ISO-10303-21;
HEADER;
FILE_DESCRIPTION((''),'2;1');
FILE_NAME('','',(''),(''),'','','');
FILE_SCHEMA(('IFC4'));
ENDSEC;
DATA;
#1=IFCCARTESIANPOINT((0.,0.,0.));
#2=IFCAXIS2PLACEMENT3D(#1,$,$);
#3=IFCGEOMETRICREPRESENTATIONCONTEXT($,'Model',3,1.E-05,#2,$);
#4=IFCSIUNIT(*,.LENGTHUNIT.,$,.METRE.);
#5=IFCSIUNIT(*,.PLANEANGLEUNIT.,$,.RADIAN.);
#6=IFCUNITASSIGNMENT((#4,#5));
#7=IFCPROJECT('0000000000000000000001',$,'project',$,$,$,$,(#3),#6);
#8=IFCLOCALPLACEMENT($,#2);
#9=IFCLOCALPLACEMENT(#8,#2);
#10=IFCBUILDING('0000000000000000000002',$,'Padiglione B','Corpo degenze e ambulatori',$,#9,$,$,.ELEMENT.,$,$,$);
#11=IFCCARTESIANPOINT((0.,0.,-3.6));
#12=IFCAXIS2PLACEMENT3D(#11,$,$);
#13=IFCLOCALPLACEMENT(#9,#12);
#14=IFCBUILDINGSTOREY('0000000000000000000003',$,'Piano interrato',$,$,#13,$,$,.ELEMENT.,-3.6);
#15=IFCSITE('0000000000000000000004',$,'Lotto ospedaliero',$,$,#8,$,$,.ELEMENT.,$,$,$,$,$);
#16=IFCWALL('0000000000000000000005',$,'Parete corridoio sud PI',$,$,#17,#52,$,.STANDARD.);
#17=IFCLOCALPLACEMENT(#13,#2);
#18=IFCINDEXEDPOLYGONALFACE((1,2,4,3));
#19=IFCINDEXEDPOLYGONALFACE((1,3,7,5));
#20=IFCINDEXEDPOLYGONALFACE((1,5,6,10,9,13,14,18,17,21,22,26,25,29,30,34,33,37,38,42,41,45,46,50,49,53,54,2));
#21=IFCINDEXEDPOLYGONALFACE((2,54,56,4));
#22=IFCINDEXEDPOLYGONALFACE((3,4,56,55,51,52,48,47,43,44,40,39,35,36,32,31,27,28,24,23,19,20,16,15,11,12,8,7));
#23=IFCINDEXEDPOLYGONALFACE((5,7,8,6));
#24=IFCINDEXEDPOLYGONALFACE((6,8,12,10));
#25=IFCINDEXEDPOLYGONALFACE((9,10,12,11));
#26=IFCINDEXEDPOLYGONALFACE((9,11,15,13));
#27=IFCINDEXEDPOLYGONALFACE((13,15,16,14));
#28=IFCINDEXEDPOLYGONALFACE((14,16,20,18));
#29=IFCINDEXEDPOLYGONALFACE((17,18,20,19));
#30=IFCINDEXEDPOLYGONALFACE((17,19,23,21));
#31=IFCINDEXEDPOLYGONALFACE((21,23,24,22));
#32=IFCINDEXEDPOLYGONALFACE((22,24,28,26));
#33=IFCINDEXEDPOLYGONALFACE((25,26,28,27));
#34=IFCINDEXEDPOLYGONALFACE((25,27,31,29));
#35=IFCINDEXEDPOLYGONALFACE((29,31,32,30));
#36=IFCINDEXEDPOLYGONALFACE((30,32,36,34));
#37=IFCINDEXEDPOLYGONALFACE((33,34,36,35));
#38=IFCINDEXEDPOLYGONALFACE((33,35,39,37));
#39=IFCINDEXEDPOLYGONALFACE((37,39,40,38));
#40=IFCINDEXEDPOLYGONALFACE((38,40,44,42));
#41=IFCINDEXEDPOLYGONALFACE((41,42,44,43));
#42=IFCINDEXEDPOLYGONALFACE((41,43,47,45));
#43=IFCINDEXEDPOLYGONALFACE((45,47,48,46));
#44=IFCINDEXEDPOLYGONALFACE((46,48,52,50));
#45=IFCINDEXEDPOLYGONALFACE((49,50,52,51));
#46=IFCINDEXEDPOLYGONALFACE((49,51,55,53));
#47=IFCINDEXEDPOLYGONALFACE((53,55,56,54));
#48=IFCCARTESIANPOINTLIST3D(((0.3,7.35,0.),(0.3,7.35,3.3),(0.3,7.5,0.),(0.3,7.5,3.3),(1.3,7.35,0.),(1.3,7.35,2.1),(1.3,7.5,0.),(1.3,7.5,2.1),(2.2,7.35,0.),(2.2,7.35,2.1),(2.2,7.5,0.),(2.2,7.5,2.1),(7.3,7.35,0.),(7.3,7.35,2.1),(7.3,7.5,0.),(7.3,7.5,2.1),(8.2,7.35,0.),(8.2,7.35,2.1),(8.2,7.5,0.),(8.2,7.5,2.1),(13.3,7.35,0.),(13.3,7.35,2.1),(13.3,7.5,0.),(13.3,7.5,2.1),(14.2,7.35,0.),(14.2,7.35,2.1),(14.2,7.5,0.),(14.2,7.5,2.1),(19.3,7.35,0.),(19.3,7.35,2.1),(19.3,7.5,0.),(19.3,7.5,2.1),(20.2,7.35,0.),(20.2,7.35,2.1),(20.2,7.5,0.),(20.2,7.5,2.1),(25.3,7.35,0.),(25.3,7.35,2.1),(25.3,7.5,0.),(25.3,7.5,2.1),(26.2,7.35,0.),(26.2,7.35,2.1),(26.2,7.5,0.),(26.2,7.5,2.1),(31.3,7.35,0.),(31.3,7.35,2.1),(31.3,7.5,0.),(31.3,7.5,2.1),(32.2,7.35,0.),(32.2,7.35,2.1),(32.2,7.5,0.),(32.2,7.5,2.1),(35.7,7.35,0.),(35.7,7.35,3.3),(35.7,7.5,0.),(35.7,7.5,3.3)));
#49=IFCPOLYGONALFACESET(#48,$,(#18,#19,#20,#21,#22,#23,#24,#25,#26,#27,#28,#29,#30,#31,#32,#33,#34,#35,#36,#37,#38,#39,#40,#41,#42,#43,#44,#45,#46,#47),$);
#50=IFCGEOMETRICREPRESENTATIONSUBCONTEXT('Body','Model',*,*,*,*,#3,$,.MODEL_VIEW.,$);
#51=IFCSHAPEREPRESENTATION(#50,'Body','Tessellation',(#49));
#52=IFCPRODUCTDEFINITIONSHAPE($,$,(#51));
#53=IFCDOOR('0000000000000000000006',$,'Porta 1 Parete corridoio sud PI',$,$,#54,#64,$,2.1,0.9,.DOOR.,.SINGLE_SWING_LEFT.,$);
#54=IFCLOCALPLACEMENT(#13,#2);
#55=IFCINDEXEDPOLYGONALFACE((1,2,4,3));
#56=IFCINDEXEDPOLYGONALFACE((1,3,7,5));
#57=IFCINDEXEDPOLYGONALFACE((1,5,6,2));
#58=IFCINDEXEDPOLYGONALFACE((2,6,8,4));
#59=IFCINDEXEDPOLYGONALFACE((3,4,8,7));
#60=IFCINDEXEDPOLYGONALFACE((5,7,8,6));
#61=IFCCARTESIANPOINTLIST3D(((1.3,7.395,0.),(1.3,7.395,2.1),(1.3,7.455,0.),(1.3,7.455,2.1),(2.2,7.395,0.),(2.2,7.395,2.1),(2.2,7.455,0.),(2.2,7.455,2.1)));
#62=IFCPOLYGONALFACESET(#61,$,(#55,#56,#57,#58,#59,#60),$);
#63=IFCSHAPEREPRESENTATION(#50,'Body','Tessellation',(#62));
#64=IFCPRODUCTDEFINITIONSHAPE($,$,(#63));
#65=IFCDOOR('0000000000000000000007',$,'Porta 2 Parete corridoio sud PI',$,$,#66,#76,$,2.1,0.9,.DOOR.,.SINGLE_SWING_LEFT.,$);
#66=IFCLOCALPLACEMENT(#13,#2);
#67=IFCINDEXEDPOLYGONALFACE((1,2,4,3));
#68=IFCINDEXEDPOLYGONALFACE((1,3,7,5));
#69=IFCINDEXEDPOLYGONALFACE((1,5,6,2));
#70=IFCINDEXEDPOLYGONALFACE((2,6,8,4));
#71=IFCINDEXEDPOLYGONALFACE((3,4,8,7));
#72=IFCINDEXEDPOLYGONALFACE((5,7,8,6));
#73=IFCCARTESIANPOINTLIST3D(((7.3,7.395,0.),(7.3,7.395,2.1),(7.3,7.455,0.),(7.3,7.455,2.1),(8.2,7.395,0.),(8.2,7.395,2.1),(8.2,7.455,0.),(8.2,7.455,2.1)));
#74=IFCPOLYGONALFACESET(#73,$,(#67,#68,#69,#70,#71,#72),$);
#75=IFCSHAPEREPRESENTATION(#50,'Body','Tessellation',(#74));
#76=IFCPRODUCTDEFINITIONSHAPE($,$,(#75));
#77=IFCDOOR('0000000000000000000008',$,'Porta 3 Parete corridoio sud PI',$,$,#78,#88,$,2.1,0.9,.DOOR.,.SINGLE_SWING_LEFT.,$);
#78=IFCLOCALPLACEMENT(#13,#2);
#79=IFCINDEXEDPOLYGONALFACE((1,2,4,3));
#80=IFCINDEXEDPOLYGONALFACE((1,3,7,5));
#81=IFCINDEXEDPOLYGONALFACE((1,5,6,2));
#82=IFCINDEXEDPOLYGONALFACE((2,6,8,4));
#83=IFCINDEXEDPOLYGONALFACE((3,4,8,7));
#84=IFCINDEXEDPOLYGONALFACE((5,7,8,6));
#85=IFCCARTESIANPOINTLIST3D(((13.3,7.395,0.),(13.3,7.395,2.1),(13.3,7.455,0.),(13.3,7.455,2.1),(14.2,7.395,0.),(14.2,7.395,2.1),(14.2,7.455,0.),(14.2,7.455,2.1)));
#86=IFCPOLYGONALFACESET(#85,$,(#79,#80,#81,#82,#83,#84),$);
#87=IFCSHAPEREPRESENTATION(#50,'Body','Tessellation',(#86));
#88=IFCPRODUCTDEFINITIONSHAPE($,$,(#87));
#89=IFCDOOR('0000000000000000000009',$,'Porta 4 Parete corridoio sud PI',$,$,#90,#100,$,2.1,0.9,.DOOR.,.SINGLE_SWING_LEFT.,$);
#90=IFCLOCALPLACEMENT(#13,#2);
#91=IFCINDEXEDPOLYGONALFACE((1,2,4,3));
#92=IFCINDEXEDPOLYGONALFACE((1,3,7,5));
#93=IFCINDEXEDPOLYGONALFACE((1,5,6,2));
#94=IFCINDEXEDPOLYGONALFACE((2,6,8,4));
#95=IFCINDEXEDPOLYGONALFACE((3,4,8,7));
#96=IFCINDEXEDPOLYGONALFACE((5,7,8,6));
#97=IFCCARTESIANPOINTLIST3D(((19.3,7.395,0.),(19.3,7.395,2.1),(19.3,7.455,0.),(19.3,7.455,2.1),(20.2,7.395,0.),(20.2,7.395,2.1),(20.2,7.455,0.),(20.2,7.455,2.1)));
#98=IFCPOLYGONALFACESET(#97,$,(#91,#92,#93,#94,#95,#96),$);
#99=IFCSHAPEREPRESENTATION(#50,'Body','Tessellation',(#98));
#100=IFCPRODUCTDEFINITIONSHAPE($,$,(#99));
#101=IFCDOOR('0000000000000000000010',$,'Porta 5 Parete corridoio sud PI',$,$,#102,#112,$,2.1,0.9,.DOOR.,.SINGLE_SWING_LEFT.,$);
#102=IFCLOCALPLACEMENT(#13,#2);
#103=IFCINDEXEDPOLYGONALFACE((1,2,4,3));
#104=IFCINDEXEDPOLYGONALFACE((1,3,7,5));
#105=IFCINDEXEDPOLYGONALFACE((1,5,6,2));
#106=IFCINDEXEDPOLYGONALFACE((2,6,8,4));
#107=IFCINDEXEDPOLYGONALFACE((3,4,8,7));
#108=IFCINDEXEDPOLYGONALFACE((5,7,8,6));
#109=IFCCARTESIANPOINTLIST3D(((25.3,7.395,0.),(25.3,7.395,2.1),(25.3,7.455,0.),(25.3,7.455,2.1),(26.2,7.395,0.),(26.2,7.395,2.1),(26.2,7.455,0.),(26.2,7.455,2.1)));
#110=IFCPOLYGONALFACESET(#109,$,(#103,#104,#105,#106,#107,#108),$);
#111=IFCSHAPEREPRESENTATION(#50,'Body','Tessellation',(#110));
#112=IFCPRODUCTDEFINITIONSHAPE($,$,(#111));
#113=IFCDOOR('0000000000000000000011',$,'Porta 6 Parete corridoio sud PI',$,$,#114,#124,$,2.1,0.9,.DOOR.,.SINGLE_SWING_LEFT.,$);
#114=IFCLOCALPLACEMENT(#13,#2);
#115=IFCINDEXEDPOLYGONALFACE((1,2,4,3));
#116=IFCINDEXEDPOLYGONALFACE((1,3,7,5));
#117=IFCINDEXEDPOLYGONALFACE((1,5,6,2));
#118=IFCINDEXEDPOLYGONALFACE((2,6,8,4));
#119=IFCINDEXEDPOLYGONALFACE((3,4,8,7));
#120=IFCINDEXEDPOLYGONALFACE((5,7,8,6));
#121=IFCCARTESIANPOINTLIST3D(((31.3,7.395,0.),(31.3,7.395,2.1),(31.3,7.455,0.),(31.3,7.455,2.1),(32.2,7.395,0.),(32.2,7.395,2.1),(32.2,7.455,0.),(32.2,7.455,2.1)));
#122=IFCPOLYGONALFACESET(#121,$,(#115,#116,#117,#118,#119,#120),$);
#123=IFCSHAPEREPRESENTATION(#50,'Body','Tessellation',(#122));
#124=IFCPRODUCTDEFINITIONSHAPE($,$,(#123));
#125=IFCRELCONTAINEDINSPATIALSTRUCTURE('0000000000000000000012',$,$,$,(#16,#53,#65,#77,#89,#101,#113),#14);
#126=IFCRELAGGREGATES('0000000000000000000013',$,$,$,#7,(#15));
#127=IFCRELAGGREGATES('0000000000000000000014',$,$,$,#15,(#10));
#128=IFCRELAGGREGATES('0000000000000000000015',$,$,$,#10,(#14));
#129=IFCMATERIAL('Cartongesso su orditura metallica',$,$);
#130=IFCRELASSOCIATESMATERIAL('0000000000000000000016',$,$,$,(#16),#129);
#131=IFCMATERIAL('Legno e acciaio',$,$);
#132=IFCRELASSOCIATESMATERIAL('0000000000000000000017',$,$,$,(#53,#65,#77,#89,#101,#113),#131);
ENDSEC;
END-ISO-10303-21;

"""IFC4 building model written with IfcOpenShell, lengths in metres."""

from ifc_helpers import new_model, si_unit, frame, frame_2d, origin, place, context, subcontext, project, spatial, rectangle, extrude, material, element, fill, save


model = new_model("IFC4")

# Units and contexts
model_context = context("Model", 3, precision=1e-05, world=origin())
body_context = subcontext(model_context, "Body", "Model", "MODEL_VIEW")
ifc_project = project(units=[si_unit("LENGTHUNIT", "METRE"), si_unit("PLANEANGLEUNIT", "RADIAN")], contexts=[model_context])

# Site, building, storey
site_placement = place(None, origin())
site = spatial("IfcSite", under=ifc_project, at=site_placement, Name="Lotto ospedaliero", CompositionType="ELEMENT")
building_placement = place(site_placement, origin())
building = spatial("IfcBuilding", under=site, at=building_placement, Name="Padiglione B", Description="Corpo degenze e ambulatori", CompositionType="ELEMENT")
storey_placement = place(building_placement, frame((0.0, 0.0, -3.6)))
storey = spatial("IfcBuildingStorey", under=building, at=storey_placement, Name="Piano interrato", CompositionType="ELEMENT", Elevation=-3.6)

# Wall, openings, doors
ifc_material_1 = material(Name="Cartongesso su orditura metallica")
wall_1_placement = place(storey_placement, frame((0.3, 7.35, 0.0)))
wall_1 = element("IfcWall", 1, at=wall_1_placement, inside=storey, material=ifc_material_1, Name="Parete corridoio sud PI", PredefinedType="STANDARD", context=body_context, shape_type="SweptSolid", body=[
    extrude(rectangle(XDim=35.4, YDim=0.15, at=frame_2d((17.7, 0.075))), origin(), (0.0, 0.0, 1.0), 3.3),
])
opening_1_placement = place(wall_1_placement, frame((1.0, -0.1, 0.0)))
opening_1 = element("IfcOpeningElement", 2, at=opening_1_placement, cuts=wall_1, PredefinedType="OPENING", context=body_context, shape_type="SweptSolid", body=[
    extrude(rectangle(XDim=0.9, YDim=0.35, at=frame_2d((0.45, 0.175))), origin(), (0.0, 0.0, 1.0), 2.1),
])
opening_2_placement = place(wall_1_placement, frame((7.0, -0.1, 0.0)))
opening_2 = element("IfcOpeningElement", 3, at=opening_2_placement, cuts=wall_1, PredefinedType="OPENING", context=body_context, shape_type="SweptSolid", body=[
    extrude(rectangle(XDim=0.9, YDim=0.35, at=frame_2d((0.45, 0.175))), origin(), (0.0, 0.0, 1.0), 2.1),
])
opening_3_placement = place(wall_1_placement, frame((13.0, -0.1, 0.0)))
opening_3 = element("IfcOpeningElement", 4, at=opening_3_placement, cuts=wall_1, PredefinedType="OPENING", context=body_context, shape_type="SweptSolid", body=[
    extrude(rectangle(XDim=0.9, YDim=0.35, at=frame_2d((0.45, 0.175))), origin(), (0.0, 0.0, 1.0), 2.1),
])
opening_4_placement = place(wall_1_placement, frame((19.0, -0.1, 0.0)))
opening_4 = element("IfcOpeningElement", 5, at=opening_4_placement, cuts=wall_1, PredefinedType="OPENING", context=body_context, shape_type="SweptSolid", body=[
    extrude(rectangle(XDim=0.9, YDim=0.35, at=frame_2d((0.45, 0.175))), origin(), (0.0, 0.0, 1.0), 2.1),
])
opening_5_placement = place(wall_1_placement, frame((25.0, -0.1, 0.0)))
opening_5 = element("IfcOpeningElement", 6, at=opening_5_placement, cuts=wall_1, PredefinedType="OPENING", context=body_context, shape_type="SweptSolid", body=[
    extrude(rectangle(XDim=0.9, YDim=0.35, at=frame_2d((0.45, 0.175))), origin(), (0.0, 0.0, 1.0), 2.1),
])
opening_6_placement = place(wall_1_placement, frame((31.0, -0.1, 0.0)))
opening_6 = element("IfcOpeningElement", 7, at=opening_6_placement, cuts=wall_1, PredefinedType="OPENING", context=body_context, shape_type="SweptSolid", body=[
    extrude(rectangle(XDim=0.9, YDim=0.35, at=frame_2d((0.45, 0.175))), origin(), (0.0, 0.0, 1.0), 2.1),
])
ifc_material_2 = material(Name="Legno e acciaio")
door_1_placement = place(wall_1_placement, frame((1.0, 0.045, 0.0)))
door_1 = element("IfcDoor", 8, at=door_1_placement, inside=storey, material=ifc_material_2, Name="Porta 1 Parete corridoio sud PI", OperationType="SINGLE_SWING_LEFT", OverallHeight=2.1, OverallWidth=0.9, PredefinedType="DOOR", context=body_context, shape_type="SweptSolid", body=[
    extrude(rectangle(XDim=0.9, YDim=0.06, at=frame_2d((0.45, 0.03))), origin(), (0.0, 0.0, 1.0), 2.1),
])
fill(opening_1, door_1)
door_2_placement = place(wall_1_placement, frame((7.0, 0.045, 0.0)))
door_2 = element("IfcDoor", 9, at=door_2_placement, inside=storey, material=ifc_material_2, Name="Porta 2 Parete corridoio sud PI", OperationType="SINGLE_SWING_LEFT", OverallHeight=2.1, OverallWidth=0.9, PredefinedType="DOOR", context=body_context, shape_type="SweptSolid", body=[
    extrude(rectangle(XDim=0.9, YDim=0.06, at=frame_2d((0.45, 0.03))), origin(), (0.0, 0.0, 1.0), 2.1),
])
fill(opening_2, door_2)
door_3_placement = place(wall_1_placement, frame((13.0, 0.045, 0.0)))
door_3 = element("IfcDoor", 10, at=door_3_placement, inside=storey, material=ifc_material_2, Name="Porta 3 Parete corridoio sud PI", OperationType="SINGLE_SWING_LEFT", OverallHeight=2.1, OverallWidth=0.9, PredefinedType="DOOR", context=body_context, shape_type="SweptSolid", body=[
    extrude(rectangle(XDim=0.9, YDim=0.06, at=frame_2d((0.45, 0.03))), origin(), (0.0, 0.0, 1.0), 2.1),
])
fill(opening_3, door_3)
door_4_placement = place(wall_1_placement, frame((19.0, 0.045, 0.0)))
door_4 = element("IfcDoor", 11, at=door_4_placement, inside=storey, material=ifc_material_2, Name="Porta 4 Parete corridoio sud PI", OperationType="SINGLE_SWING_LEFT", OverallHeight=2.1, OverallWidth=0.9, PredefinedType="DOOR", context=body_context, shape_type="SweptSolid", body=[
    extrude(rectangle(XDim=0.9, YDim=0.06, at=frame_2d((0.45, 0.03))), origin(), (0.0, 0.0, 1.0), 2.1),
])
fill(opening_4, door_4)
door_5_placement = place(wall_1_placement, frame((25.0, 0.045, 0.0)))
door_5 = element("IfcDoor", 12, at=door_5_placement, inside=storey, material=ifc_material_2, Name="Porta 5 Parete corridoio sud PI", OperationType="SINGLE_SWING_LEFT", OverallHeight=2.1, OverallWidth=0.9, PredefinedType="DOOR", context=body_context, shape_type="SweptSolid", body=[
    extrude(rectangle(XDim=0.9, YDim=0.06, at=frame_2d((0.45, 0.03))), origin(), (0.0, 0.0, 1.0), 2.1),
])
fill(opening_5, door_5)
door_6_placement = place(wall_1_placement, frame((31.0, 0.045, 0.0)))
door_6 = element("IfcDoor", 13, at=door_6_placement, inside=storey, material=ifc_material_2, Name="Porta 6 Parete corridoio sud PI", OperationType="SINGLE_SWING_LEFT", OverallHeight=2.1, OverallWidth=0.9, PredefinedType="DOOR", context=body_context, shape_type="SweptSolid", body=[
    extrude(rectangle(XDim=0.9, YDim=0.06, at=frame_2d((0.45, 0.03))), origin(), (0.0, 0.0, 1.0), 2.1),
])
fill(opening_6, door_6)

save(model, "model.ifc")
